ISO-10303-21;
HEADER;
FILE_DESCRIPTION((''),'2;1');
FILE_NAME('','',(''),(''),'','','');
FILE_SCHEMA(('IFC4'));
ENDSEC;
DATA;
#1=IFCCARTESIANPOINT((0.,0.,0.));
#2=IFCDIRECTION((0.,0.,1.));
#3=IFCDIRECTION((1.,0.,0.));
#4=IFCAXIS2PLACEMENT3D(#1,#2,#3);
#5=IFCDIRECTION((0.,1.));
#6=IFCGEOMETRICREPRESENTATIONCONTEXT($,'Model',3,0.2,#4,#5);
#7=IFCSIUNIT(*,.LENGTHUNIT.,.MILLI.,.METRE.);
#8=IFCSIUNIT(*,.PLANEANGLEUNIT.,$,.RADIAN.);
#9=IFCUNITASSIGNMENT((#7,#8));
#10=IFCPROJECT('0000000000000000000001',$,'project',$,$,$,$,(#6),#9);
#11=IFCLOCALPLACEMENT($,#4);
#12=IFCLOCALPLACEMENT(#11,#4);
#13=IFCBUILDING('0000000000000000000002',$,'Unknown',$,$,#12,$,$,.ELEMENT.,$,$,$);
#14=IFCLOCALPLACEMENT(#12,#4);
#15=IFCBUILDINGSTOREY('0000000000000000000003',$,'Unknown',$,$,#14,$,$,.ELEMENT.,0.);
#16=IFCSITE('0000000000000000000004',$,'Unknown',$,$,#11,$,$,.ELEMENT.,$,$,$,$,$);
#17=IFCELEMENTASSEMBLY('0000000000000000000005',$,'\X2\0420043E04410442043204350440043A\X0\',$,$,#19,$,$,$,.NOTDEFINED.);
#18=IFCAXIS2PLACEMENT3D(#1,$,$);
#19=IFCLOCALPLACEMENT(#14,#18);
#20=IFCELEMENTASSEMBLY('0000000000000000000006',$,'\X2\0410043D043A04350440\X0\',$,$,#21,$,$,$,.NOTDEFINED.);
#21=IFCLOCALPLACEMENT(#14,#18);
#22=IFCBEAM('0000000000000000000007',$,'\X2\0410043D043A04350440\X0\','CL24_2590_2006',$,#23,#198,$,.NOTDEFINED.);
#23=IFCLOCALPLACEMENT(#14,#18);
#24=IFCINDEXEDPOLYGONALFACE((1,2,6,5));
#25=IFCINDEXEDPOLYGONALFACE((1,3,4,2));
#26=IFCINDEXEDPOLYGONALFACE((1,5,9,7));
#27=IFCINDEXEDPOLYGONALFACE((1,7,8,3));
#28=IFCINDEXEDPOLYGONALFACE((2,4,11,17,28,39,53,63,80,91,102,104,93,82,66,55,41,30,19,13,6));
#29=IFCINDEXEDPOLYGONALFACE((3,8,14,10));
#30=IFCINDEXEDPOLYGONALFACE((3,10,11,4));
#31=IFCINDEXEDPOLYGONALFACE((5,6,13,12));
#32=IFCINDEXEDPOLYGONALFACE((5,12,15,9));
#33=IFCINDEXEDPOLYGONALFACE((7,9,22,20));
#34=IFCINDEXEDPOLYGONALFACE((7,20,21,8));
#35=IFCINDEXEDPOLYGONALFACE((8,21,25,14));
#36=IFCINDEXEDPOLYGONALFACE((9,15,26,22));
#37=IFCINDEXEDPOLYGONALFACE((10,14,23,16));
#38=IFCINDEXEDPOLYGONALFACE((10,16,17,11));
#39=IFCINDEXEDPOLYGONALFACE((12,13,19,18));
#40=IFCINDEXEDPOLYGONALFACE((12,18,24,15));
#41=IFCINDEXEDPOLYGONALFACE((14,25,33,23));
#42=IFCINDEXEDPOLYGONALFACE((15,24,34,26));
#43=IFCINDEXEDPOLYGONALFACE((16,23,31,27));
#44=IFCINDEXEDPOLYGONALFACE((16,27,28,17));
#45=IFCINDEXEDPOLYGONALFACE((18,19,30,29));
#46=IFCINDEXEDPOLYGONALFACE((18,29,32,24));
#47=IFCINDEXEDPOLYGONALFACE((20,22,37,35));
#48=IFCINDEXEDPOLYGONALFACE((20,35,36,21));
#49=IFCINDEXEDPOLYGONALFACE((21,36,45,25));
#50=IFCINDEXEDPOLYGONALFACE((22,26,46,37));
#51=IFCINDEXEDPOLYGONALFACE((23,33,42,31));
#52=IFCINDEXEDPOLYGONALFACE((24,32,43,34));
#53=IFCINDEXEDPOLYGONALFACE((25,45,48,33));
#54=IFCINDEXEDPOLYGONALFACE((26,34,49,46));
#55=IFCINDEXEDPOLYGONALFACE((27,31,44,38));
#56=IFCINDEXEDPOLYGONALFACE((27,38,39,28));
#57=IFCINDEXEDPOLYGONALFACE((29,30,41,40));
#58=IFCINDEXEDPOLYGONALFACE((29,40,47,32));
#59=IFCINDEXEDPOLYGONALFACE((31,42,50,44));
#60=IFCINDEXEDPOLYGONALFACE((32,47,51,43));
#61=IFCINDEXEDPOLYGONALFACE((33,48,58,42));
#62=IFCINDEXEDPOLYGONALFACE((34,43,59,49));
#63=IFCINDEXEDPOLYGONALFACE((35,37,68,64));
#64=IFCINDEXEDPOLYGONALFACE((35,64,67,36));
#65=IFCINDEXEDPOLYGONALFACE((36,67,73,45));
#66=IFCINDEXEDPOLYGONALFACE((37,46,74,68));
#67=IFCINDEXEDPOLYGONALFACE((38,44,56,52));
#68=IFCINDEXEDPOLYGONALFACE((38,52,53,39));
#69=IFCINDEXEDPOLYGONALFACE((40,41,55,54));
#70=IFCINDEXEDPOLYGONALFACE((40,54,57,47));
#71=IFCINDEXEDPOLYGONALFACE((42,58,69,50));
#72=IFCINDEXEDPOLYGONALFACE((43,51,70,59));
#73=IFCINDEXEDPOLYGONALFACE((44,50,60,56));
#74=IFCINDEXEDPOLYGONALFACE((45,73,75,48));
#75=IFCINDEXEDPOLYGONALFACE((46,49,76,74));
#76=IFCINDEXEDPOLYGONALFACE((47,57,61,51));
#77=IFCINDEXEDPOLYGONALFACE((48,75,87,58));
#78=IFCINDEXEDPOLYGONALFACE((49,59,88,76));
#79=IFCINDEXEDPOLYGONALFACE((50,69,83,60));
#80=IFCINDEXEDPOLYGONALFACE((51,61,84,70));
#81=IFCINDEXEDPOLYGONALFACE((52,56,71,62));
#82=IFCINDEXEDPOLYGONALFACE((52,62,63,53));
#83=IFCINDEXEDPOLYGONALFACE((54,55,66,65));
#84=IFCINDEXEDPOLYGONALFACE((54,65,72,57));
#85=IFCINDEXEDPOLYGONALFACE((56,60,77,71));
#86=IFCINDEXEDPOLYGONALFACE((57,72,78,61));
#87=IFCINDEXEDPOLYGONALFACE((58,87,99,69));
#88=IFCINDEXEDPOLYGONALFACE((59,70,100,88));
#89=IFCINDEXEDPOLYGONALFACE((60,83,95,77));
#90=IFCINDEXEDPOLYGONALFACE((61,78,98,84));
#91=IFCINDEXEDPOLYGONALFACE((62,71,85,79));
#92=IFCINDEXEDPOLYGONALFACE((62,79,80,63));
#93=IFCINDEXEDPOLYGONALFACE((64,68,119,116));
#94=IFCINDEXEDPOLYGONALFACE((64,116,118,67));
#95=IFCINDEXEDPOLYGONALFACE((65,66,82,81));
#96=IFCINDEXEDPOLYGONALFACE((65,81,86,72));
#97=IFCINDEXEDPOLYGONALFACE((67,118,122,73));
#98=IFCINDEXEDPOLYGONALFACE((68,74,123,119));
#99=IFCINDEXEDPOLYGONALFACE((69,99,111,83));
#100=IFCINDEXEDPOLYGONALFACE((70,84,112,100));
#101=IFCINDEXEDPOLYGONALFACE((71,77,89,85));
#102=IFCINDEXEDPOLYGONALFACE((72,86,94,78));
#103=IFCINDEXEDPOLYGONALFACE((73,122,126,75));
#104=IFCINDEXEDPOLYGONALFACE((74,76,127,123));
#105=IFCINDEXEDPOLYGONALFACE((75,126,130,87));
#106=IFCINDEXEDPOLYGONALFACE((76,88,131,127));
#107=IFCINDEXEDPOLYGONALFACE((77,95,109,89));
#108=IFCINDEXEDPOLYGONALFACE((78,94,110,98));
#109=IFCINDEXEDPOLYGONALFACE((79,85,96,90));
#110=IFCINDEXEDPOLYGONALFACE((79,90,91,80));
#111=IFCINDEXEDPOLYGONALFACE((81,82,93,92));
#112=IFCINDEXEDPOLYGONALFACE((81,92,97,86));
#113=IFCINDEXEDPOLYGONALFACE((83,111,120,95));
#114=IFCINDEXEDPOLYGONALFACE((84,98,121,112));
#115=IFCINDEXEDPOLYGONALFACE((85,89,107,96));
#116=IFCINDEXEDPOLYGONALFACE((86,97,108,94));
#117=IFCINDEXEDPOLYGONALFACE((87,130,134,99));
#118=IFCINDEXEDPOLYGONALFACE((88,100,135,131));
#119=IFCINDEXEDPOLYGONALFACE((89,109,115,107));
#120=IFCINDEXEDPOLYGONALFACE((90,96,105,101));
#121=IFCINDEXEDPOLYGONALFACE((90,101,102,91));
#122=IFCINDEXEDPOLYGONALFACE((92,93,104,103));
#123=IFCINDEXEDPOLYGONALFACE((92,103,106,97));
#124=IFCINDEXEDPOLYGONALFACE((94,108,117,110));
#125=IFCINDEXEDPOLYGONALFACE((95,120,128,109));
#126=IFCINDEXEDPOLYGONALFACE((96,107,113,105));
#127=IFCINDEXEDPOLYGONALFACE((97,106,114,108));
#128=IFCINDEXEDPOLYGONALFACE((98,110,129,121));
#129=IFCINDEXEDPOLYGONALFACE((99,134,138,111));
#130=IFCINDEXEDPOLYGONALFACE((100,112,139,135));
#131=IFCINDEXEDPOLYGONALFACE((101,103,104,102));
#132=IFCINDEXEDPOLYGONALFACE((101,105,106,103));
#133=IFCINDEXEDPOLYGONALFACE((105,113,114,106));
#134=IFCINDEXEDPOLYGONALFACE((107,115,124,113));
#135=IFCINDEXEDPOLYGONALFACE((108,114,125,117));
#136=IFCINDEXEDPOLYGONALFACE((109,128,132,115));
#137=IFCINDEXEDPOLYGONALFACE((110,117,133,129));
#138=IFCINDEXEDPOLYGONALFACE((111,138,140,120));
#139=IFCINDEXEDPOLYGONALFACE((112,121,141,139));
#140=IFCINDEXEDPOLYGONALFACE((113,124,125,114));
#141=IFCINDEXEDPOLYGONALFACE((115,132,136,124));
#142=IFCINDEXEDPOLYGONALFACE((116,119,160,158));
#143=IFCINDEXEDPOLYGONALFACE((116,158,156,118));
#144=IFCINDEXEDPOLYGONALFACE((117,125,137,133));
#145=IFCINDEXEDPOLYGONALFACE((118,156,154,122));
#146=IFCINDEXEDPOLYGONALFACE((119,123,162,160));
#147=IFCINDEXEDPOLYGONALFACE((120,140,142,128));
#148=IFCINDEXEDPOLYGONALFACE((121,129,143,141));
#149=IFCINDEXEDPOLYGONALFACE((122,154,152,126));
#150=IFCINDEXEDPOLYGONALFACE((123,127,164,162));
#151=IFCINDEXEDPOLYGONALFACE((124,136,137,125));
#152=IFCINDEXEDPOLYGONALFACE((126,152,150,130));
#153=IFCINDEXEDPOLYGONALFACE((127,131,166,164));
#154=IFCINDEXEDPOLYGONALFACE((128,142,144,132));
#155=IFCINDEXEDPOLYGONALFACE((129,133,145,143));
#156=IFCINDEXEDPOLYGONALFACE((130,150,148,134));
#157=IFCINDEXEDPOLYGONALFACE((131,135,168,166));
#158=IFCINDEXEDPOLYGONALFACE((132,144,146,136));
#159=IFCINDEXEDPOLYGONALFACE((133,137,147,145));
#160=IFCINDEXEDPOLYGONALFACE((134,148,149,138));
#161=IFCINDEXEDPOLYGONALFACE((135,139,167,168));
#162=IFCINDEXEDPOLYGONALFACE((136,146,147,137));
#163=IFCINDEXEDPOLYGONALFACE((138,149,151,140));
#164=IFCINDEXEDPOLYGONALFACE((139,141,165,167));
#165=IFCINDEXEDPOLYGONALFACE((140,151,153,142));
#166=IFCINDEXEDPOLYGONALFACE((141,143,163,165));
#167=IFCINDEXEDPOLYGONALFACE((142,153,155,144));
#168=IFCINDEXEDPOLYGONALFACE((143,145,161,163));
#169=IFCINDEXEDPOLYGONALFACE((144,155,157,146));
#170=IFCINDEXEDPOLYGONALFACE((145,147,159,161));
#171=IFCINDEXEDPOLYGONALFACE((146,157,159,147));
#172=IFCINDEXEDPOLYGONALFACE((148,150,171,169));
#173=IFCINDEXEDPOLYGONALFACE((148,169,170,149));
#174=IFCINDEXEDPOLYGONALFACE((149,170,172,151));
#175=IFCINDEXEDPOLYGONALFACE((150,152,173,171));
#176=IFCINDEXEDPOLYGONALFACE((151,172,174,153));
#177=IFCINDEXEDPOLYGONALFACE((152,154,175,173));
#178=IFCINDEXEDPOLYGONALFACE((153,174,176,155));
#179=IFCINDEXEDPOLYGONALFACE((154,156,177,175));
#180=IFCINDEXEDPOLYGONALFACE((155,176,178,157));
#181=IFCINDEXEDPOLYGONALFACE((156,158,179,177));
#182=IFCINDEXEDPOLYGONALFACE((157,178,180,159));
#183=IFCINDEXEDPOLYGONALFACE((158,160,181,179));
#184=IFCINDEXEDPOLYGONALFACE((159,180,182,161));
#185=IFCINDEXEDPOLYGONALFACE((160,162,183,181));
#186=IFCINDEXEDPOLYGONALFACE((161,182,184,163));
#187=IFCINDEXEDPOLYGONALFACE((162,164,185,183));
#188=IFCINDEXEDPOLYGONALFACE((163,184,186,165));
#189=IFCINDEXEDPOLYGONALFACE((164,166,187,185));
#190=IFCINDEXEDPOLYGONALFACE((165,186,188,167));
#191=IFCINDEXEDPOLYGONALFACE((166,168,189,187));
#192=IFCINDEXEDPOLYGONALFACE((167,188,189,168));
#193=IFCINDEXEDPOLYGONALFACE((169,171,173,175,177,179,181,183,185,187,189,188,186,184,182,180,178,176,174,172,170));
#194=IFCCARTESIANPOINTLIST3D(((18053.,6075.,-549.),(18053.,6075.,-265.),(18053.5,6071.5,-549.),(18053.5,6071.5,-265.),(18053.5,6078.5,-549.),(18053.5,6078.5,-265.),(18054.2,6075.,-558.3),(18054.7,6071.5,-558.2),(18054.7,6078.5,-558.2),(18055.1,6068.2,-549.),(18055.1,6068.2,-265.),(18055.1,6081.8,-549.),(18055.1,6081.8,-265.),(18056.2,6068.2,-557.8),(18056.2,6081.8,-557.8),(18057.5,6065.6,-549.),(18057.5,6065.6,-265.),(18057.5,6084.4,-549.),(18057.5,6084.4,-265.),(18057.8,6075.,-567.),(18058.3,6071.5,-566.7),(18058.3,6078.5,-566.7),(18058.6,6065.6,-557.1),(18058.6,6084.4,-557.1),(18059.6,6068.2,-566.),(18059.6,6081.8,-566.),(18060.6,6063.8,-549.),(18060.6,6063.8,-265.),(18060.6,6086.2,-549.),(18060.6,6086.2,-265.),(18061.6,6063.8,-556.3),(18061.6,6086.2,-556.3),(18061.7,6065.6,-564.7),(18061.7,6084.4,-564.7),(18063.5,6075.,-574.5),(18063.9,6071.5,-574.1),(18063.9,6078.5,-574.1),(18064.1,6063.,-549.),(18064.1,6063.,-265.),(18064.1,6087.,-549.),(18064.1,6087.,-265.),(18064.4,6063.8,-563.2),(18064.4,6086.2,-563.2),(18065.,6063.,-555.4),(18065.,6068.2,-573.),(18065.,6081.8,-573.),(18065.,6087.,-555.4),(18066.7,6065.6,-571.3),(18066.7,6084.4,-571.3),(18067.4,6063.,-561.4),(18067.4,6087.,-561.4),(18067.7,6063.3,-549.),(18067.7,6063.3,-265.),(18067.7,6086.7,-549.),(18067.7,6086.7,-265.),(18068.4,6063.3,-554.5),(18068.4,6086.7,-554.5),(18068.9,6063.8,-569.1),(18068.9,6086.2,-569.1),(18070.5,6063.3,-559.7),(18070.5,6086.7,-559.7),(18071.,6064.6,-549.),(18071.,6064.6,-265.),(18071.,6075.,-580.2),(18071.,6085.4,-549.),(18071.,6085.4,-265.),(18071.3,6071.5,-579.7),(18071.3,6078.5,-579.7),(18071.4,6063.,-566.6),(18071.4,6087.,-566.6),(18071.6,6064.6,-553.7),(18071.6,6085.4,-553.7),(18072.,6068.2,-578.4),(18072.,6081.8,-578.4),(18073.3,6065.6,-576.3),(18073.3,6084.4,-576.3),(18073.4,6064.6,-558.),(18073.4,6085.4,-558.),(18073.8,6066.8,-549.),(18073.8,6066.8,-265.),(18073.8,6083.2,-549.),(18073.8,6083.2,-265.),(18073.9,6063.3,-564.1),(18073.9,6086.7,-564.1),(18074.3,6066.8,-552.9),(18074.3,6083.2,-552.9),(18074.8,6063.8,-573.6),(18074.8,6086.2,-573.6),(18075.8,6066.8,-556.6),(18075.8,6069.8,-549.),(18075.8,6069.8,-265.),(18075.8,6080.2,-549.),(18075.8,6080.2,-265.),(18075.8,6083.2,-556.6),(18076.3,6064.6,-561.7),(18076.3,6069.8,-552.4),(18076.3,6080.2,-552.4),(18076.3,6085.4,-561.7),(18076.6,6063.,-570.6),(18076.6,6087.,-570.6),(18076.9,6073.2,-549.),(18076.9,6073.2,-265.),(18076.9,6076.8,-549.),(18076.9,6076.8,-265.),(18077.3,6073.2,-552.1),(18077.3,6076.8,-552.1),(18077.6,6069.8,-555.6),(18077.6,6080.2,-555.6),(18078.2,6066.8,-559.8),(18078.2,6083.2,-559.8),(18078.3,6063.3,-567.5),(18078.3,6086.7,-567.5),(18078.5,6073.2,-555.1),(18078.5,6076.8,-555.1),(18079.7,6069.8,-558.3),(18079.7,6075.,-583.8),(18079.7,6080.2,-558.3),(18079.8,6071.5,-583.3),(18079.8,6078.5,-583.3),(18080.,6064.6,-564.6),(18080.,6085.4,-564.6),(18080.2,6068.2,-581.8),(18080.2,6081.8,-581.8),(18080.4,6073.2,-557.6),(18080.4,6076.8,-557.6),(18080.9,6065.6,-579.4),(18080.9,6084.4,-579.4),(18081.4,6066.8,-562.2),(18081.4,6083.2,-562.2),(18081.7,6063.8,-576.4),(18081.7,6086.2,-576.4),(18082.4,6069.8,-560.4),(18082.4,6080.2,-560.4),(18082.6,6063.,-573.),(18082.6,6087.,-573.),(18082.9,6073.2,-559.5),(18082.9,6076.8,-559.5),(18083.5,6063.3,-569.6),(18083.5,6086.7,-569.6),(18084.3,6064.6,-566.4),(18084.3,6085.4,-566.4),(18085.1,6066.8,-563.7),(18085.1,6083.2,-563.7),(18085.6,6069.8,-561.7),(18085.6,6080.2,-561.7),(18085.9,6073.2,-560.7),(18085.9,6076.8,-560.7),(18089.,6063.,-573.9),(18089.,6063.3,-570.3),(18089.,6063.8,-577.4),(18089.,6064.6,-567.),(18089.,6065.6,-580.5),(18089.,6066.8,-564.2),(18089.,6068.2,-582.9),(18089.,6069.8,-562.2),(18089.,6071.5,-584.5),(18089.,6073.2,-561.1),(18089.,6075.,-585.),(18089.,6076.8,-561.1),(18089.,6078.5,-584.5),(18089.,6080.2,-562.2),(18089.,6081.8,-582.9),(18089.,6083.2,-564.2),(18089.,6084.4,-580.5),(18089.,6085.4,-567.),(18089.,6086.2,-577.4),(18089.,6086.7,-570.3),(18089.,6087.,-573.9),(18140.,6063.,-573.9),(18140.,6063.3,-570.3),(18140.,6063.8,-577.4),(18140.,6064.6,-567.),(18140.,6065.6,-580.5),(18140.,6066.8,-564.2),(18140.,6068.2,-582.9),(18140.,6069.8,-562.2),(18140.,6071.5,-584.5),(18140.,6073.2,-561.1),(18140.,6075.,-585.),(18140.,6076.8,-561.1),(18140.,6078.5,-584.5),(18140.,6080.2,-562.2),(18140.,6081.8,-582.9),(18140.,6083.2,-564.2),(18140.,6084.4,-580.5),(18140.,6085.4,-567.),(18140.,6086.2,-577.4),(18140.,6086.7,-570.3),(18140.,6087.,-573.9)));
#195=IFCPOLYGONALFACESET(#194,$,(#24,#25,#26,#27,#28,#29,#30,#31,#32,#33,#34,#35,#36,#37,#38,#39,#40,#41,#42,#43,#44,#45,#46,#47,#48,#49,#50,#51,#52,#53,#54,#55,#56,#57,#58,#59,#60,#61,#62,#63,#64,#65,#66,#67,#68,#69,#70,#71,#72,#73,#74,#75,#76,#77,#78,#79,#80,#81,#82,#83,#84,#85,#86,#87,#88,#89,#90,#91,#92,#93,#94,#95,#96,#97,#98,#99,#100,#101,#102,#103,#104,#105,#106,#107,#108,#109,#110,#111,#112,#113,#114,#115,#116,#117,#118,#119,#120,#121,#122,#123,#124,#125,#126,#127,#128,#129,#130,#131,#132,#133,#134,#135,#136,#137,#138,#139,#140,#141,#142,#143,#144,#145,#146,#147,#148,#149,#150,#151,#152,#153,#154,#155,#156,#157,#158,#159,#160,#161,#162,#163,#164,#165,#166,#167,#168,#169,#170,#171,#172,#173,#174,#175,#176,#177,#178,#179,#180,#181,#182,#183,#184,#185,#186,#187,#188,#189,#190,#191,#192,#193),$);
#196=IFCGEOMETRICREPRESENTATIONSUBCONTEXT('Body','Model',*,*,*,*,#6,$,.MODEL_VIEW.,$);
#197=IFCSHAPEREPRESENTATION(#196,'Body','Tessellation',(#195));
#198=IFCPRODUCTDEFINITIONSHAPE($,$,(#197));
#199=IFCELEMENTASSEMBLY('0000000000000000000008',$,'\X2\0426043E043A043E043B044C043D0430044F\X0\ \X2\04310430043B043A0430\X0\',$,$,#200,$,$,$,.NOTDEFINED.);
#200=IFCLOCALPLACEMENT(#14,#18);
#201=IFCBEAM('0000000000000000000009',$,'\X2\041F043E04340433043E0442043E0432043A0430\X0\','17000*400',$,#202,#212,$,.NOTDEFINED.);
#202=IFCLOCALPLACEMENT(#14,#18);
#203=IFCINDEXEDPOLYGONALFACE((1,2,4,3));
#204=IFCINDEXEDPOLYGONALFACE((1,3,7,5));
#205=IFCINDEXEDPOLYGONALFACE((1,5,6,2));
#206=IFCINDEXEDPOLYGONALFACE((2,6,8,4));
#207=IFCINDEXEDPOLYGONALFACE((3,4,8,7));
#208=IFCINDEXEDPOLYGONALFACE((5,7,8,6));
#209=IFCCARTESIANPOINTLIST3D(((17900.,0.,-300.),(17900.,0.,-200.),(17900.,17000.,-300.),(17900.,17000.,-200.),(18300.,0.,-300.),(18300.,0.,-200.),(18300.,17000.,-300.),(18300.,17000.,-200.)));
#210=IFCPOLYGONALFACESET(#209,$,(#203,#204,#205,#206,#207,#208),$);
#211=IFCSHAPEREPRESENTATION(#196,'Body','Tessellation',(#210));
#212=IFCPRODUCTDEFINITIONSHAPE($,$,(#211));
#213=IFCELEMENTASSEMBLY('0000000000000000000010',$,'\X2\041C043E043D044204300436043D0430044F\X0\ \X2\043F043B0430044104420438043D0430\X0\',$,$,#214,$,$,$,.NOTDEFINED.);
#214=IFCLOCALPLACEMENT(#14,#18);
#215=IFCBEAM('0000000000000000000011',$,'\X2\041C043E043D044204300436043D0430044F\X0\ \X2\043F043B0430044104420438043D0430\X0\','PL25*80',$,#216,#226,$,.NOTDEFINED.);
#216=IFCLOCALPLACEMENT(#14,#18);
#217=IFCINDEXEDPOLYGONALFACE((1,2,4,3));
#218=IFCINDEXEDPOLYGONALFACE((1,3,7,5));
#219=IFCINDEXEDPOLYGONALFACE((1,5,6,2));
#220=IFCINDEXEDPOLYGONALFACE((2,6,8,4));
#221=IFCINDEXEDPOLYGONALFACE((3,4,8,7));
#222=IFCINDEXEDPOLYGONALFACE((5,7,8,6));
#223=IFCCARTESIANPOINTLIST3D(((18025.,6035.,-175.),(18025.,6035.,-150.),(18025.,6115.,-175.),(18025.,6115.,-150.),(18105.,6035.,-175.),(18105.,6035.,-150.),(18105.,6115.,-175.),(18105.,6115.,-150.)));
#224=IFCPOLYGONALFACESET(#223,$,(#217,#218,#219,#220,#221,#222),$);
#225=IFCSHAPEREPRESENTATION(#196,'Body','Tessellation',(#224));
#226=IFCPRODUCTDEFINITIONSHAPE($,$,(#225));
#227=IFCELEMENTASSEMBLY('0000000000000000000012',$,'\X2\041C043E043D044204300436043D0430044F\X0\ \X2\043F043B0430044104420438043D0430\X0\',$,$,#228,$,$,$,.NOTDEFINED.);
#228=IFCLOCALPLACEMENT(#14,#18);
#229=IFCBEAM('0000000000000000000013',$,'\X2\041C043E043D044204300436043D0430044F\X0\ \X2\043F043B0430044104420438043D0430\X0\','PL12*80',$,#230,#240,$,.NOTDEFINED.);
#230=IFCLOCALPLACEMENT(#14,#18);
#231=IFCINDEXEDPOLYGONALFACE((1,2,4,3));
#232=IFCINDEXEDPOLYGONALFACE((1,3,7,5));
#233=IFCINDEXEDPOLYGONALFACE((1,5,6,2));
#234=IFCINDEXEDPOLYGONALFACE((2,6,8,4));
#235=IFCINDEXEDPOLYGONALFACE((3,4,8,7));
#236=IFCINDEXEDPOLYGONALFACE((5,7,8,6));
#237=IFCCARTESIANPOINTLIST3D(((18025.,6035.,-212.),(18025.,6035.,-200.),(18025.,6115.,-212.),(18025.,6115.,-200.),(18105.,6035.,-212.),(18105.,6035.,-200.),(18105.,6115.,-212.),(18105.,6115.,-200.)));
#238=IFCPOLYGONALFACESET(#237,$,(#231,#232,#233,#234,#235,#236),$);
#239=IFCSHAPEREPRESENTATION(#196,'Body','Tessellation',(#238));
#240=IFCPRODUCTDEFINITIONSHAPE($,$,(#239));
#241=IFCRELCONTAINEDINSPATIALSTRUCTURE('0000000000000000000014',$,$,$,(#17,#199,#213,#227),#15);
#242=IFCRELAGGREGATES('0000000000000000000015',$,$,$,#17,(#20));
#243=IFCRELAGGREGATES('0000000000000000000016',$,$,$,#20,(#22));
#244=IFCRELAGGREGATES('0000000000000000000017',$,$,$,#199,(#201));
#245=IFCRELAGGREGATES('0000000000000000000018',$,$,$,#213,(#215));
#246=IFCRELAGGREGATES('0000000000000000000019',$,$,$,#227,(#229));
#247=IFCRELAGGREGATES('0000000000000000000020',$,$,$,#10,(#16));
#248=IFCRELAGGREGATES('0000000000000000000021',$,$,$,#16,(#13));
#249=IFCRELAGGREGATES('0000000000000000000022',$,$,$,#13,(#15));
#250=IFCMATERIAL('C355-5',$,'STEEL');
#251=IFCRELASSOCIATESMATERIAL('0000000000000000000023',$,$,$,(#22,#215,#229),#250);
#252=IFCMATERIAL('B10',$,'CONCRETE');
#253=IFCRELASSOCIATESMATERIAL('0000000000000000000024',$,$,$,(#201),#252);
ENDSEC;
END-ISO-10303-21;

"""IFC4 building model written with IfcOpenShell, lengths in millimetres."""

from ifc_helpers import new_model, entity, si_unit, direction, frame, origin_with_axes, place, context, subcontext, project, spatial, line, indexed_curve, outline, extrude, material, element, aggregate, save


model = new_model("IFC4")

# Units and contexts
model_context = context("Model", 3, precision=0.2, world=origin_with_axes(), true_north=direction((0.0, 1.0)))
body_context = subcontext(model_context, "Body", "Model", "MODEL_VIEW")
ifc_project = project(units=[si_unit("LENGTHUNIT", "METRE", prefix="MILLI"), si_unit("PLANEANGLEUNIT", "RADIAN")], contexts=[model_context])

# Site, building, storey
site_placement = place(None, origin_with_axes())
site = spatial("IfcSite", under=ifc_project, at=site_placement, Name="Unknown", CompositionType="ELEMENT")
building_placement = place(site_placement, origin_with_axes())
building = spatial("IfcBuilding", under=site, at=building_placement, Name="Unknown", CompositionType="ELEMENT")
storey_placement = place(building_placement, origin_with_axes())
storey = spatial("IfcBuildingStorey", under=building, at=storey_placement, Name="Unknown", CompositionType="ELEMENT", Elevation=0.0)

# Element assemblies, beam, voiding feature
assembly_1_placement = place(storey_placement, frame((17827.0, 6000.0, -300.0), z_axis=(0.0, -1.0, 0.0), x_axis=(0.0, 0.0, -1.0)))
assembly_1 = element("IfcElementAssembly", 1, at=assembly_1_placement, inside=storey, Name="Ростверк", PredefinedType="NOTDEFINED")
assembly_2_placement = place(assembly_1_placement, frame((-215.0, 238.0, -75.0), z_axis=(0.0, -1.0, 0.0), x_axis=(1.0, 0.0, 0.0)))
assembly_2 = element("IfcElementAssembly", 2, at=assembly_2_placement, Name="Анкер", PredefinedType="NOTDEFINED")
aggregate(assembly_1, [assembly_2])
ifc_material_1 = material(Name="C355-5", Category="STEEL")
beam_1_placement = place(assembly_2_placement, origin_with_axes())
beam_1 = element("IfcBeam", 3, at=beam_1_placement, material=ifc_material_1, Name="Анкер", Description="CL24_2590_2006", PredefinedType="NOTDEFINED", context=body_context, shape_type="SolidModel", body=[
    entity("IfcSweptDiskSolid", entity("IfcIndexedPolyCurve", entity("IfcCartesianPointList3D", [[0.0, 0.0, 0.0], [464.0, 0.0, 0.0], [481.0, 0.0, -7.0], [488.0, 0.0, -24.0], [488.0, 0.0, -75.0]]), [entity("IfcLineIndex", [1, 2]), entity("IfcArcIndex", [2, 3, 4]), entity("IfcLineIndex", [4, 5])]), 12.0),
])
voiding_feature_1_placement = place(beam_1_placement, frame((0.0, 0.0, 0.0), z_axis=(0.0, -1.0, 0.0), x_axis=(1.0, 0.0, 0.0)))
element("IfcVoidingFeature", 4, at=voiding_feature_1_placement, cuts=beam_1, Name="Анкер", PredefinedType="HOLE", context=body_context, shape_type="SolidModel", body=[
    extrude(outline(indexed_curve([(12.5, 0.0), (12.2, 2.8), (11.3, 5.4), (9.8, 7.8), (7.8, 9.8), (5.4, 11.3), (2.8, 12.2), (0.0, 12.5), (-2.8, 12.2), (-5.4, 11.3), (-7.8, 9.8), (-9.8, 7.8), (-11.3, 5.4), (-12.2, 2.8), (-12.5, 0.0), (-12.2, -2.8), (-11.3, -5.4), (-9.8, -7.8), (-7.8, -9.8), (-5.4, -11.3), (-2.8, -12.2), (0.0, -12.5), (2.8, -12.2), (5.4, -11.3), (7.8, -9.8), (9.8, -7.8), (11.3, -5.4), (12.2, -2.8)], segments=[line(1, 2, 3, 4, 5, 6, 7, 8, 9, 10, 11, 12, 13, 14, 15, 16, 17, 18, 19, 20, 21, 22, 23, 24, 25, 26, 27, 28, 1)])), frame((0.0, 0.0, 0.0), z_axis=(-1.0, 0.0, 0.0), x_axis=(0.0, 0.0, 1.0)), (0.0, 0.0, -1.0), 180.0),
])
aggregate(assembly_2, [beam_1])

# Element assemblies, beams
assembly_3_placement = place(storey_placement, frame((18200.0, 17100.0, 100.0), z_axis=(0.0, 1.0, 0.0), x_axis=(-1.0, 0.0, 0.0)))
assembly_3 = element("IfcElementAssembly", 5, at=assembly_3_placement, inside=storey, Name="Цокольная балка", PredefinedType="NOTDEFINED")
ifc_material_2 = material(Name="B10", Category="CONCRETE")
beam_2_placement = place(assembly_3_placement, frame((100.0, -300.0, -8600.0), z_axis=(-1.0, 0.0, 0.0), x_axis=(0.0, -1.0, 0.0)))
beam_2 = element("IfcBeam", 6, at=beam_2_placement, material=ifc_material_2, Name="Подготовка", Description="17000*400", PredefinedType="NOTDEFINED", context=body_context, shape_type="SolidModel", body=[
    extrude(outline(indexed_curve([(-200.0, -8500.0), (200.0, -8500.0), (200.0, 8500.0), (-200.0, 8500.0)], segments=[line(1, 2, 3, 4, 1)])), frame((0.0, 0.0, 0.0), z_axis=(-1.0, 0.0, 0.0), x_axis=(0.0, 0.0, 1.0)), (0.0, 0.0, -1.0), 100.0),
])
aggregate(assembly_3, [beam_2])
assembly_4_placement = place(storey_placement, frame((18065.0, 6115.0, -162.5), z_axis=(0.0, 0.0, -1.0), x_axis=(0.0, -1.0, 0.0)))
assembly_4 = element("IfcElementAssembly", 7, at=assembly_4_placement, inside=storey, Name="Монтажная пластина", PredefinedType="NOTDEFINED")
beam_3_placement = place(assembly_4_placement, origin_with_axes())
beam_3 = element("IfcBeam", 8, at=beam_3_placement, material=ifc_material_1, Name="Монтажная пластина", Description="PL25*80", PredefinedType="NOTDEFINED", context=body_context, shape_type="SolidModel", body=[
    extrude(outline(indexed_curve([(-12.5, -40.0), (12.5, -40.0), (12.5, 40.0), (-12.5, 40.0)], segments=[line(1, 2, 3, 4, 1)])), frame((0.0, 0.0, 0.0), z_axis=(-1.0, 0.0, 0.0), x_axis=(0.0, 0.0, 1.0)), (0.0, 0.0, -1.0), 80.0),
])
aggregate(assembly_4, [beam_3])
assembly_5_placement = place(storey_placement, frame((18065.0, 6115.0, -206.0), z_axis=(0.0, 0.0, -1.0), x_axis=(0.0, -1.0, 0.0)))
assembly_5 = element("IfcElementAssembly", 9, at=assembly_5_placement, inside=storey, Name="Монтажная пластина", PredefinedType="NOTDEFINED")
beam_4_placement = place(assembly_5_placement, origin_with_axes())
beam_4 = element("IfcBeam", 10, at=beam_4_placement, material=ifc_material_1, Name="Монтажная пластина", Description="PL12*80", PredefinedType="NOTDEFINED", context=body_context, shape_type="SolidModel", body=[
    extrude(outline(indexed_curve([(-6.0, -40.0), (6.0, -40.0), (6.0, 40.0), (-6.0, 40.0)], segments=[line(1, 2, 3, 4, 1)])), frame((0.0, 0.0, 0.0), z_axis=(-1.0, 0.0, 0.0), x_axis=(0.0, 0.0, 1.0)), (0.0, 0.0, -1.0), 80.0),
])
aggregate(assembly_5, [beam_4])

save(model, "model.ifc")
